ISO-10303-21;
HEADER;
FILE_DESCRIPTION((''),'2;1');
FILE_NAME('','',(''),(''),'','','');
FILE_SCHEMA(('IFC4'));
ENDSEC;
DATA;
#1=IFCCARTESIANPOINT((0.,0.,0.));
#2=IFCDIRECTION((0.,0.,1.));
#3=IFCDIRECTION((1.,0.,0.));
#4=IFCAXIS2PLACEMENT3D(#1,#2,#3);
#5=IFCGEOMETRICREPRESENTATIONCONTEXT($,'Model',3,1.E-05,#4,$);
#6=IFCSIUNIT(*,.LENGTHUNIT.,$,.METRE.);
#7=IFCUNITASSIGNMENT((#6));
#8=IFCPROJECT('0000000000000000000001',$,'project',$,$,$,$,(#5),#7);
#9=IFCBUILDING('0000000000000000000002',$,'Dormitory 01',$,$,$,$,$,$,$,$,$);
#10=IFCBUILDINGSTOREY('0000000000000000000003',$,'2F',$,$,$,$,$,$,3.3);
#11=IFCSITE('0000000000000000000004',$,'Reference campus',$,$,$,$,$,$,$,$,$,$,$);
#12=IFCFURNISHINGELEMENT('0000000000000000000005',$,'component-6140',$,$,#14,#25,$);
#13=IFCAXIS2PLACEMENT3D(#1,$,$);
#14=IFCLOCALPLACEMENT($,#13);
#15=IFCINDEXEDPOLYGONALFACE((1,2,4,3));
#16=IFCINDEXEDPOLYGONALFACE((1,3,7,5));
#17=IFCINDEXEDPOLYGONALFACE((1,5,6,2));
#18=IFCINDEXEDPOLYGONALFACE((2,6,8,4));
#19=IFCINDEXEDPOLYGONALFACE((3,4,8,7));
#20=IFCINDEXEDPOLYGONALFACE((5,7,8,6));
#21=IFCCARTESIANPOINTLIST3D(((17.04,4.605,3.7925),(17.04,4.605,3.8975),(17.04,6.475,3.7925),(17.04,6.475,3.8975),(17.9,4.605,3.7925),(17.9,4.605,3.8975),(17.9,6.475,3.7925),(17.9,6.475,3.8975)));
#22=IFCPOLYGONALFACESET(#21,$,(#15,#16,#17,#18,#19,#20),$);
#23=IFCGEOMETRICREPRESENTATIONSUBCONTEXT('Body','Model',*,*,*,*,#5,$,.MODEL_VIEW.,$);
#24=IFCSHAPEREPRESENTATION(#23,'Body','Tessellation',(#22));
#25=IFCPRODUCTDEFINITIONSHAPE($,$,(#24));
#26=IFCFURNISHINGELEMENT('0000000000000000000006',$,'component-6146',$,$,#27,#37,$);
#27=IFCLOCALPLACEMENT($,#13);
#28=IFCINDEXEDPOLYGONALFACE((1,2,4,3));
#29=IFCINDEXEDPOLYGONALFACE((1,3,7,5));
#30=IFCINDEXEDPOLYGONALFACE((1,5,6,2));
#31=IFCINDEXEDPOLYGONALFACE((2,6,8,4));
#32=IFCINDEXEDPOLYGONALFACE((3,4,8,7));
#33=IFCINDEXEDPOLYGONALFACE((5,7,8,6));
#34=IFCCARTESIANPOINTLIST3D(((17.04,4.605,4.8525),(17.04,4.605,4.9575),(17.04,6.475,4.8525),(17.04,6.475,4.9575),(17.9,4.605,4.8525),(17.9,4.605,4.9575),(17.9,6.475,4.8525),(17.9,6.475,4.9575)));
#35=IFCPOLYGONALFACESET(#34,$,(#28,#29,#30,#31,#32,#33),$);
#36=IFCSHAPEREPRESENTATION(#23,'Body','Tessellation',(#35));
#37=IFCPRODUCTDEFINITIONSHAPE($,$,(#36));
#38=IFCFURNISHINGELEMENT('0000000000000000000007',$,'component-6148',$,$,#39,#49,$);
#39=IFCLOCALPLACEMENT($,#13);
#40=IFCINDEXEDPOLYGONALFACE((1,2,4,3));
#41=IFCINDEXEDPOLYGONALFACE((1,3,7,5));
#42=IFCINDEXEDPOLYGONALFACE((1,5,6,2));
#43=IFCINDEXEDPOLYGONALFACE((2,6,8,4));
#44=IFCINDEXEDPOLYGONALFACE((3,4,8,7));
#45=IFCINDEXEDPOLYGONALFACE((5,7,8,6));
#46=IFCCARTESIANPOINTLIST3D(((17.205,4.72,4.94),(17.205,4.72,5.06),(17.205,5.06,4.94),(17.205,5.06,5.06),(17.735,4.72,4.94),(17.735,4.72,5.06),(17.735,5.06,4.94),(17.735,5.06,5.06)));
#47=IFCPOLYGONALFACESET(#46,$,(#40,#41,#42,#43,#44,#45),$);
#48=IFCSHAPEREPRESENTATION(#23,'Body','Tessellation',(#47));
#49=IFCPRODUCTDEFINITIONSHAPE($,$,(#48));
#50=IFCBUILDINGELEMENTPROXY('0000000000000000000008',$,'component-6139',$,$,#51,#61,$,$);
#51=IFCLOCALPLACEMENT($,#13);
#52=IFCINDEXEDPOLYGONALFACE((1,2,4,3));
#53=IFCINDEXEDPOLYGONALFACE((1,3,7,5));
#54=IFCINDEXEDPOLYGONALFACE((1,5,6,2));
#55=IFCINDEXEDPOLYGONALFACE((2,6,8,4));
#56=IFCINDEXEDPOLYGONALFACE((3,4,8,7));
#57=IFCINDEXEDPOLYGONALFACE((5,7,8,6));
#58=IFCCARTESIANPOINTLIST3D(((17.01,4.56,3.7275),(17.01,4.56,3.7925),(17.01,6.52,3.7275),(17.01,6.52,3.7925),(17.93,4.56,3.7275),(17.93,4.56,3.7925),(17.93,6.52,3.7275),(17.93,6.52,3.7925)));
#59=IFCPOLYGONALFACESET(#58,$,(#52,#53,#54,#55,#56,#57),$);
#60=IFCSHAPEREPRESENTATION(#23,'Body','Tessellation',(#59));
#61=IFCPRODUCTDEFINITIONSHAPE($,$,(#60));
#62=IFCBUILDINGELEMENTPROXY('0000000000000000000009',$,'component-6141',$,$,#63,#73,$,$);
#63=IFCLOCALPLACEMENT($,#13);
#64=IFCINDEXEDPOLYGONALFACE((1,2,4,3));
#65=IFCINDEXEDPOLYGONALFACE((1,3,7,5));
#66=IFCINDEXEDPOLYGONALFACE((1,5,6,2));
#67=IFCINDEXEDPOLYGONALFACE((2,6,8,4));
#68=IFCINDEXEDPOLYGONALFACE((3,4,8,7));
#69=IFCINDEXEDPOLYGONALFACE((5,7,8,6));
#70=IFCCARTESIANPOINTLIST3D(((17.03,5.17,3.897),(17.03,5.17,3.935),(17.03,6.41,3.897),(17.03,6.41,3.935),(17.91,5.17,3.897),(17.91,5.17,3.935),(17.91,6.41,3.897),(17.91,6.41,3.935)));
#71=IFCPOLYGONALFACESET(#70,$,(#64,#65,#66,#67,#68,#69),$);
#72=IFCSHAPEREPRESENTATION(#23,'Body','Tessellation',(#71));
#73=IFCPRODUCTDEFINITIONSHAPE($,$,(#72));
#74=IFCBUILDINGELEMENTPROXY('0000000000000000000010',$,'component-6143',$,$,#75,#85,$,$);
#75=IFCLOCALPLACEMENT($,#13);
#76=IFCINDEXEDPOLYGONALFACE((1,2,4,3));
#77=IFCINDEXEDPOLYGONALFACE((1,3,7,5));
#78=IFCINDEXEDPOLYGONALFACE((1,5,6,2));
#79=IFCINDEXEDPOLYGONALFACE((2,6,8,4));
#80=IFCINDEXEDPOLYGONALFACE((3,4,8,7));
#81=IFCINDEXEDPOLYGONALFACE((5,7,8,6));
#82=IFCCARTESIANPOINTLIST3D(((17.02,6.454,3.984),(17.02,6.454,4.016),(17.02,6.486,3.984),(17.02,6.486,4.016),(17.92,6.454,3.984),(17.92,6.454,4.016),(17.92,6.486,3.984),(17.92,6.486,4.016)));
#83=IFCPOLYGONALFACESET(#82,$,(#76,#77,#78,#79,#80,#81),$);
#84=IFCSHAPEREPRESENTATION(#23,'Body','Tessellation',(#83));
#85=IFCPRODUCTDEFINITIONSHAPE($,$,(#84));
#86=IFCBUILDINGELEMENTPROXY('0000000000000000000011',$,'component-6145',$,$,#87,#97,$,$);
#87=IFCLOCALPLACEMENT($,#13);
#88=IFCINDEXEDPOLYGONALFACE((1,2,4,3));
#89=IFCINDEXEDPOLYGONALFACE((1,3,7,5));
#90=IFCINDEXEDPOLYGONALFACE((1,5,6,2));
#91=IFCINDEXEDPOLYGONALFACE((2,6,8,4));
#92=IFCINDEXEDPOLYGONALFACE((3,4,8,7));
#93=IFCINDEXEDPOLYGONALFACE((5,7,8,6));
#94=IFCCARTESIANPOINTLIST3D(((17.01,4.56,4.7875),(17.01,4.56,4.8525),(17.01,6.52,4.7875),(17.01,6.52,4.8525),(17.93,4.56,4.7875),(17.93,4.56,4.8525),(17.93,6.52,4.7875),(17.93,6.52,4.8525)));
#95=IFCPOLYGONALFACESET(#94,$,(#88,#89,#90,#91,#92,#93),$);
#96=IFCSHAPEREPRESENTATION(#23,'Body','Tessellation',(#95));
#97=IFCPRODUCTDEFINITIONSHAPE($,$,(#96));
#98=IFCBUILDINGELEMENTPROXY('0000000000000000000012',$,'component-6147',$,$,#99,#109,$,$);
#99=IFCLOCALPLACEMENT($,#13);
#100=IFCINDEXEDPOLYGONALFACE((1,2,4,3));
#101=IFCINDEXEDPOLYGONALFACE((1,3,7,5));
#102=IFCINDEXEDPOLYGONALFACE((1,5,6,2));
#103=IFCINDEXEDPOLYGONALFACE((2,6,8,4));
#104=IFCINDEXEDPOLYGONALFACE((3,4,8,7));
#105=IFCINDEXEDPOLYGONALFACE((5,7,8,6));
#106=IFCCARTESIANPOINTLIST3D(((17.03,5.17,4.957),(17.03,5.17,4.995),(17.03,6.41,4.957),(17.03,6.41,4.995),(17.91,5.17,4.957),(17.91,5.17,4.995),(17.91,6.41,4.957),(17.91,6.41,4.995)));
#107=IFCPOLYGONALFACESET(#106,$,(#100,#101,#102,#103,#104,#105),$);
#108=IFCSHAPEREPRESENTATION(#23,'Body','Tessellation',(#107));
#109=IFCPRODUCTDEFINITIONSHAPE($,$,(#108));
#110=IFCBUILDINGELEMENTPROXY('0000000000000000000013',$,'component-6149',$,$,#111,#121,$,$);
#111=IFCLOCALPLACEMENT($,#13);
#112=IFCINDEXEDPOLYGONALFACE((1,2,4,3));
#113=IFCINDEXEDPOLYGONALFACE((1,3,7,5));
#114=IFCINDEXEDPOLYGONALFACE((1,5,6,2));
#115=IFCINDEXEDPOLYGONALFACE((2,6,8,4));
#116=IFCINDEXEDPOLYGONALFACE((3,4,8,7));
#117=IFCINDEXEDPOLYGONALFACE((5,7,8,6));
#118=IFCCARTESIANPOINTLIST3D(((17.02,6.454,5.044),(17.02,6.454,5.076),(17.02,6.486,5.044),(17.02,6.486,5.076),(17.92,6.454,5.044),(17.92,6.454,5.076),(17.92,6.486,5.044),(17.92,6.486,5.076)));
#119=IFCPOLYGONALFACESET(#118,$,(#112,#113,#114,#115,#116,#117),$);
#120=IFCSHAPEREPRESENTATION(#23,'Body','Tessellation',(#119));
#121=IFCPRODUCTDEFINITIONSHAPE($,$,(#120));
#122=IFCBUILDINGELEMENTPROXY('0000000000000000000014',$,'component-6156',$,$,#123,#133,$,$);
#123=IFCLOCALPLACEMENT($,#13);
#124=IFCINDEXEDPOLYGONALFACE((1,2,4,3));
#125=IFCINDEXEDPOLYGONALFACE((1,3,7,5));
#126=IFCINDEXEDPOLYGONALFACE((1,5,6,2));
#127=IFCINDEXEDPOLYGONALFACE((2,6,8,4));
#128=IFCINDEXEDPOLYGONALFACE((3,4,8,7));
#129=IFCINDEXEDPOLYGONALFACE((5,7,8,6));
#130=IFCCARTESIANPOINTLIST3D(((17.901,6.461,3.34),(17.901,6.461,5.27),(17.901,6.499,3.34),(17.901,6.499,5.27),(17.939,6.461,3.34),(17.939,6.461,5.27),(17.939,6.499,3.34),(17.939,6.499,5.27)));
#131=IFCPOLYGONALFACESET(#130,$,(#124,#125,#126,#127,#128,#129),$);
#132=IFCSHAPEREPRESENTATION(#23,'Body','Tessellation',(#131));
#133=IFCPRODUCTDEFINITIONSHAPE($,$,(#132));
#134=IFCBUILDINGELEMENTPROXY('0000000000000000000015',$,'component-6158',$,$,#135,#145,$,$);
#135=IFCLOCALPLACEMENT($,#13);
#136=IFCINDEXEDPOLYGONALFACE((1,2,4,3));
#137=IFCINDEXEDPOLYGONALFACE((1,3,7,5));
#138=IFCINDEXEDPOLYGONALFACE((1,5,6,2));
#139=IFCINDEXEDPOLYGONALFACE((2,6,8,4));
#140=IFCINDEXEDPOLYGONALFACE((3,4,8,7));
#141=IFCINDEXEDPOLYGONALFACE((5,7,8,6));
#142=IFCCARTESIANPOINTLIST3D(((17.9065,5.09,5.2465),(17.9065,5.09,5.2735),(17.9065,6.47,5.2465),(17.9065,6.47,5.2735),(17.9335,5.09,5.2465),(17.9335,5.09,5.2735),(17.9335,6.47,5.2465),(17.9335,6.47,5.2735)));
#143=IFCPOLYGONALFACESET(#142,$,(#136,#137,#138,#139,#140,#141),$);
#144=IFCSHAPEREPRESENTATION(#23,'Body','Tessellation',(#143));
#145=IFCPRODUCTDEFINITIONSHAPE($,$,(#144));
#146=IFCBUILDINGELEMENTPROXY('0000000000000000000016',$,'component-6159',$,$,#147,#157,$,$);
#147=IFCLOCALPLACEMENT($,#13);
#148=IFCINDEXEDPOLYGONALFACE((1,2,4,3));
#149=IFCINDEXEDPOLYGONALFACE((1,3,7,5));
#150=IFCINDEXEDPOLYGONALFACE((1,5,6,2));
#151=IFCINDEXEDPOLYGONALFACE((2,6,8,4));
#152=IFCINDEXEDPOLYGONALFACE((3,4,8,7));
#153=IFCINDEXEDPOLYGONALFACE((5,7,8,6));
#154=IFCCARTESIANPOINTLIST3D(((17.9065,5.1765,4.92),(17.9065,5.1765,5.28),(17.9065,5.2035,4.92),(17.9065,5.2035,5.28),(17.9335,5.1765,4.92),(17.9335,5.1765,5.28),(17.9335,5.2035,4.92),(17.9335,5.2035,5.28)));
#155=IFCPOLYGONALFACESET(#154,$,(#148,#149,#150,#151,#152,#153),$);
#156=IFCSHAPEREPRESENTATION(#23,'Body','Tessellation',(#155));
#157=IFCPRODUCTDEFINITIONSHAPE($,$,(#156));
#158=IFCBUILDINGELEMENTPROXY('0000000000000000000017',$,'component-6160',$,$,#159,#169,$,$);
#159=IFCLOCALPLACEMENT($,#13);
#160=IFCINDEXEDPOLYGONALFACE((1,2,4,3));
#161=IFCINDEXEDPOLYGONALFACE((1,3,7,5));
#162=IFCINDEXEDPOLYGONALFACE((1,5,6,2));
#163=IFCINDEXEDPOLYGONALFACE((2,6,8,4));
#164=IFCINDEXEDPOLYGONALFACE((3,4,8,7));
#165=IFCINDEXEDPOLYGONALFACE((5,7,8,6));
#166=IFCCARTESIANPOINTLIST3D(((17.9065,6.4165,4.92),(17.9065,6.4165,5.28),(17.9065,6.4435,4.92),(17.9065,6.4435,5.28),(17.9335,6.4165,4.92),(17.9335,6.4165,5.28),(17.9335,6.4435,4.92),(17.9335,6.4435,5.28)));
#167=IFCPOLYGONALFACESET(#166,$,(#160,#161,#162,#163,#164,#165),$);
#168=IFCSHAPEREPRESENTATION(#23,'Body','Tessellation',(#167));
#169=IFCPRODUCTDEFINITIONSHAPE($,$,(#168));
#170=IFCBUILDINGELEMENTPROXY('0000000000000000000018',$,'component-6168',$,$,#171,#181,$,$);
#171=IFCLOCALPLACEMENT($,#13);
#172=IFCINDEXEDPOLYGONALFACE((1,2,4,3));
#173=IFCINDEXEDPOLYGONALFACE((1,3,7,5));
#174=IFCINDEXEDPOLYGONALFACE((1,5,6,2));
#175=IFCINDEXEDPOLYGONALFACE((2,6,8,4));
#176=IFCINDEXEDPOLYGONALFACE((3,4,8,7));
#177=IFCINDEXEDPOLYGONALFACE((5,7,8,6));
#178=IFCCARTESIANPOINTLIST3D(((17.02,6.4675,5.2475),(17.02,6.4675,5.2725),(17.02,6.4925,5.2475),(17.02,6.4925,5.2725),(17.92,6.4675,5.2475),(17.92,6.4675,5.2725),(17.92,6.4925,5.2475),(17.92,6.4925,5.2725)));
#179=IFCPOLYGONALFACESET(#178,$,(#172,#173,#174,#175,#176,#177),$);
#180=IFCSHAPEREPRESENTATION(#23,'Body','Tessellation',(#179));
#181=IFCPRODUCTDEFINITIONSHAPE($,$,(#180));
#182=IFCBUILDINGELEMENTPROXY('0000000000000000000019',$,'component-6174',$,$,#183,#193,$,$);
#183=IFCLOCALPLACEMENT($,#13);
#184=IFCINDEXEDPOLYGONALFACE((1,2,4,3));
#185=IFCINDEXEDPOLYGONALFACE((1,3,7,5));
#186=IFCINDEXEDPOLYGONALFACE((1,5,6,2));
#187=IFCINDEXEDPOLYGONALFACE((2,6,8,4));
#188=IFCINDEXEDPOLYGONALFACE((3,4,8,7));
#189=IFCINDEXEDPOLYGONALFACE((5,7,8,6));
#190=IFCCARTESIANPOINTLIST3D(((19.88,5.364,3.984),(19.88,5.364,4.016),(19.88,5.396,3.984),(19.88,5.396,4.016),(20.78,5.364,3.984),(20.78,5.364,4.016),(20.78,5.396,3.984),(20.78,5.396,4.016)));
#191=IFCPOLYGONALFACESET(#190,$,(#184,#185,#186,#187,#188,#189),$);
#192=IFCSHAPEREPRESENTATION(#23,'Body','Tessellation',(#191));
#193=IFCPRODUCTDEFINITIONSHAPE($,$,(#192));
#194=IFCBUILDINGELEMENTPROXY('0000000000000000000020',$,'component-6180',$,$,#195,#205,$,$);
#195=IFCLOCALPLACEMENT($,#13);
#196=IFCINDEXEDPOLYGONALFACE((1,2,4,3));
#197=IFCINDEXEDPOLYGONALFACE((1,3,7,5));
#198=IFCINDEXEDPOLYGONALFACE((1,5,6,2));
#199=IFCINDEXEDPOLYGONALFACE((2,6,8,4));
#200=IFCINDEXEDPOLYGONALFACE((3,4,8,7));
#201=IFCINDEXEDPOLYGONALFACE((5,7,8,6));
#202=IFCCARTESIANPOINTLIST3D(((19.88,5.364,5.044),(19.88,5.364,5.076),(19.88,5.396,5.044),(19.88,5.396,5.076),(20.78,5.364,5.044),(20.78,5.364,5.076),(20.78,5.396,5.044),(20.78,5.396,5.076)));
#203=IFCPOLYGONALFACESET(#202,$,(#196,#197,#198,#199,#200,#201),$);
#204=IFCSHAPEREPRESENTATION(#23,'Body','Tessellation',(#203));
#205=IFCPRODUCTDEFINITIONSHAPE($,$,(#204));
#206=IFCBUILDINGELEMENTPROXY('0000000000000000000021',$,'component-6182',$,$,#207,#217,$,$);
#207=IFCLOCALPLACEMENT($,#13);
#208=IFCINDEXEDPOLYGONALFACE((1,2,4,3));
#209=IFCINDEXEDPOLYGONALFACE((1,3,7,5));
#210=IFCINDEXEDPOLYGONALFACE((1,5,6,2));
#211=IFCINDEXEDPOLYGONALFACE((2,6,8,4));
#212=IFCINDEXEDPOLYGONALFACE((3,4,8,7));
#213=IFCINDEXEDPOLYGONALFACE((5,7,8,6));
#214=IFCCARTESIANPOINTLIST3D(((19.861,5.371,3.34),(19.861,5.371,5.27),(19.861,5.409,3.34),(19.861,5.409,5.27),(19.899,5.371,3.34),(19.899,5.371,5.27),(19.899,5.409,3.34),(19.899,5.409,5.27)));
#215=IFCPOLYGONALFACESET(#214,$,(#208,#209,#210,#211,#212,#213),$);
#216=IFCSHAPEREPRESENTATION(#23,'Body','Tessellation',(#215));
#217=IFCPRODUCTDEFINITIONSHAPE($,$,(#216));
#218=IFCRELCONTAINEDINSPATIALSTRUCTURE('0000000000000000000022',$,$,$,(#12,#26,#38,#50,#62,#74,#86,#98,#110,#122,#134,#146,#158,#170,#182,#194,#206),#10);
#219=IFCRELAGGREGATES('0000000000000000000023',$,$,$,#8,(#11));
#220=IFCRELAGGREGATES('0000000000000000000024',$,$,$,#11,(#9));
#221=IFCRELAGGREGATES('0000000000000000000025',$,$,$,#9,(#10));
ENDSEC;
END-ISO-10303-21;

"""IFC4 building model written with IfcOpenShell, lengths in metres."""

from ifc_helpers import new_model, si_unit, frame, origin, origin_with_axes, origin_2d, place, context, subcontext, project, spatial, rectangle, extrude, element, save


model = new_model("IFC4")

# Units and contexts
model_context = context("Model", 3, precision=1e-05, world=origin_with_axes())
body_context = subcontext(model_context, "Body", "Model", "MODEL_VIEW")
ifc_project = project(units=[si_unit("LENGTHUNIT", "METRE")], contexts=[model_context])

# Site, building, storey
site = spatial("IfcSite", under=ifc_project, Name="Reference campus")
building = spatial("IfcBuilding", under=site, Name="Dormitory 01")
storey = spatial("IfcBuildingStorey", under=building, Name="2F", Elevation=3.3)

# Furnishing elements
for number, where, z_axis, x_axis, name in (
    (1, (17.47, 5.54, 3.7925), (0.0, 0.0, 1.0), (1.0, 0.0, 0.0), "component-6140"),
    (2, (17.47, 5.54, 4.8525), (0.0, 0.0, 1.0), (1.0, 0.0, 0.0), "component-6146"),
):
    element("IfcFurnishingElement", number, at=place(None, frame(where, z_axis=z_axis, x_axis=x_axis)), inside=storey, Name=name, context=body_context, shape_type="SweptSolid", body=[
        extrude(rectangle(XDim=0.86, YDim=1.87, at=origin_2d()), origin(), (0.0, 0.0, 1.0), 0.105),
    ])
furnishing_placement = place(None, frame((17.47, 4.89, 4.94), z_axis=(0.0, 0.0, 1.0), x_axis=(1.0, 0.0, 0.0)))
element("IfcFurnishingElement", 3, at=furnishing_placement, inside=storey, Name="component-6148", context=body_context, shape_type="SweptSolid", body=[
    extrude(rectangle(XDim=0.53, YDim=0.34, at=origin_2d()), origin(), (0.0, 0.0, 1.0), 0.12),
])

# Building element proxies
proxy_1_placement = place(None, frame((17.47, 5.54, 3.7275), z_axis=(0.0, 0.0, 1.0), x_axis=(1.0, 0.0, 0.0)))
element("IfcBuildingElementProxy", 4, at=proxy_1_placement, inside=storey, Name="component-6139", context=body_context, shape_type="SweptSolid", body=[
    extrude(rectangle(XDim=0.92, YDim=1.96, at=origin_2d()), origin(), (0.0, 0.0, 1.0), 0.065),
])
proxy_2_placement = place(None, frame((17.47, 5.79, 3.897), z_axis=(0.0, 0.0, 1.0), x_axis=(1.0, 0.0, 0.0)))
element("IfcBuildingElementProxy", 5, at=proxy_2_placement, inside=storey, Name="component-6141", context=body_context, shape_type="SweptSolid", body=[
    extrude(rectangle(XDim=0.88, YDim=1.24, at=origin_2d()), origin(), (0.0, 0.0, 1.0), 0.038),
])
proxy_3_placement = place(None, frame((17.47, 6.47, 3.984), z_axis=(0.0, 0.0, 1.0), x_axis=(1.0, 0.0, 0.0)))
element("IfcBuildingElementProxy", 6, at=proxy_3_placement, inside=storey, Name="component-6143", context=body_context, shape_type="SweptSolid", body=[
    extrude(rectangle(XDim=0.9, YDim=0.032, at=origin_2d()), origin(), (0.0, 0.0, 1.0), 0.032),
])
proxy_4_placement = place(None, frame((17.47, 5.54, 4.7875), z_axis=(0.0, 0.0, 1.0), x_axis=(1.0, 0.0, 0.0)))
element("IfcBuildingElementProxy", 7, at=proxy_4_placement, inside=storey, Name="component-6145", context=body_context, shape_type="SweptSolid", body=[
    extrude(rectangle(XDim=0.92, YDim=1.96, at=origin_2d()), origin(), (0.0, 0.0, 1.0), 0.065),
])
proxy_5_placement = place(None, frame((17.47, 5.79, 4.957), z_axis=(0.0, 0.0, 1.0), x_axis=(1.0, 0.0, 0.0)))
element("IfcBuildingElementProxy", 8, at=proxy_5_placement, inside=storey, Name="component-6147", context=body_context, shape_type="SweptSolid", body=[
    extrude(rectangle(XDim=0.88, YDim=1.24, at=origin_2d()), origin(), (0.0, 0.0, 1.0), 0.038),
])
proxy_6_placement = place(None, frame((17.47, 6.47, 5.044), z_axis=(0.0, 0.0, 1.0), x_axis=(1.0, 0.0, 0.0)))
element("IfcBuildingElementProxy", 9, at=proxy_6_placement, inside=storey, Name="component-6149", context=body_context, shape_type="SweptSolid", body=[
    extrude(rectangle(XDim=0.9, YDim=0.032, at=origin_2d()), origin(), (0.0, 0.0, 1.0), 0.032),
])
proxy_7_placement = place(None, frame((17.92, 6.48, 3.34), z_axis=(0.0, 0.0, 1.0), x_axis=(1.0, 0.0, 0.0)))
element("IfcBuildingElementProxy", 10, at=proxy_7_placement, inside=storey, Name="component-6156", context=body_context, shape_type="SweptSolid", body=[
    extrude(rectangle(XDim=0.038, YDim=0.038, at=origin_2d()), origin(), (0.0, 0.0, 1.0), 1.93),
])
proxy_8_placement = place(None, frame((17.92, 5.78, 5.2465), z_axis=(0.0, 0.0, 1.0), x_axis=(1.0, 0.0, 0.0)))
element("IfcBuildingElementProxy", 11, at=proxy_8_placement, inside=storey, Name="component-6158", context=body_context, shape_type="SweptSolid", body=[
    extrude(rectangle(XDim=0.027, YDim=1.38, at=origin_2d()), origin(), (0.0, 0.0, 1.0), 0.027),
])
for number, where, z_axis, x_axis, name in (
    (12, (17.92, 5.19, 4.92), (0.0, 0.0, 1.0), (1.0, 0.0, 0.0), "component-6159"),
    (13, (17.92, 6.43, 4.92), (0.0, 0.0, 1.0), (1.0, 0.0, 0.0), "component-6160"),
):
    element("IfcBuildingElementProxy", number, at=place(None, frame(where, z_axis=z_axis, x_axis=x_axis)), inside=storey, Name=name, context=body_context, shape_type="SweptSolid", body=[
        extrude(rectangle(XDim=0.027, YDim=0.027, at=origin_2d()), origin(), (0.0, 0.0, 1.0), 0.36),
    ])
proxy_9_placement = place(None, frame((17.47, 6.48, 5.2475), z_axis=(0.0, 0.0, 1.0), x_axis=(1.0, 0.0, 0.0)))
element("IfcBuildingElementProxy", 14, at=proxy_9_placement, inside=storey, Name="component-6168", context=body_context, shape_type="SweptSolid", body=[
    extrude(rectangle(XDim=0.9, YDim=0.025, at=origin_2d()), origin(), (0.0, 0.0, 1.0), 0.025),
])
for number, where, z_axis, x_axis, name in (
    (15, (20.33, 5.38, 3.984), (0.0, 0.0, 1.0), (1.0, 0.0, 0.0), "component-6174"),
    (16, (20.33, 5.38, 5.044), (0.0, 0.0, 1.0), (1.0, 0.0, 0.0), "component-6180"),
):
    element("IfcBuildingElementProxy", number, at=place(None, frame(where, z_axis=z_axis, x_axis=x_axis)), inside=storey, Name=name, context=body_context, shape_type="SweptSolid", body=[
        extrude(rectangle(XDim=0.9, YDim=0.032, at=origin_2d()), origin(), (0.0, 0.0, 1.0), 0.032),
    ])
proxy_10_placement = place(None, frame((19.88, 5.39, 3.34), z_axis=(0.0, 0.0, 1.0), x_axis=(1.0, 0.0, 0.0)))
element("IfcBuildingElementProxy", 17, at=proxy_10_placement, inside=storey, Name="component-6182", context=body_context, shape_type="SweptSolid", body=[
    extrude(rectangle(XDim=0.038, YDim=0.038, at=origin_2d()), origin(), (0.0, 0.0, 1.0), 1.93),
])

save(model, "model.ifc")
